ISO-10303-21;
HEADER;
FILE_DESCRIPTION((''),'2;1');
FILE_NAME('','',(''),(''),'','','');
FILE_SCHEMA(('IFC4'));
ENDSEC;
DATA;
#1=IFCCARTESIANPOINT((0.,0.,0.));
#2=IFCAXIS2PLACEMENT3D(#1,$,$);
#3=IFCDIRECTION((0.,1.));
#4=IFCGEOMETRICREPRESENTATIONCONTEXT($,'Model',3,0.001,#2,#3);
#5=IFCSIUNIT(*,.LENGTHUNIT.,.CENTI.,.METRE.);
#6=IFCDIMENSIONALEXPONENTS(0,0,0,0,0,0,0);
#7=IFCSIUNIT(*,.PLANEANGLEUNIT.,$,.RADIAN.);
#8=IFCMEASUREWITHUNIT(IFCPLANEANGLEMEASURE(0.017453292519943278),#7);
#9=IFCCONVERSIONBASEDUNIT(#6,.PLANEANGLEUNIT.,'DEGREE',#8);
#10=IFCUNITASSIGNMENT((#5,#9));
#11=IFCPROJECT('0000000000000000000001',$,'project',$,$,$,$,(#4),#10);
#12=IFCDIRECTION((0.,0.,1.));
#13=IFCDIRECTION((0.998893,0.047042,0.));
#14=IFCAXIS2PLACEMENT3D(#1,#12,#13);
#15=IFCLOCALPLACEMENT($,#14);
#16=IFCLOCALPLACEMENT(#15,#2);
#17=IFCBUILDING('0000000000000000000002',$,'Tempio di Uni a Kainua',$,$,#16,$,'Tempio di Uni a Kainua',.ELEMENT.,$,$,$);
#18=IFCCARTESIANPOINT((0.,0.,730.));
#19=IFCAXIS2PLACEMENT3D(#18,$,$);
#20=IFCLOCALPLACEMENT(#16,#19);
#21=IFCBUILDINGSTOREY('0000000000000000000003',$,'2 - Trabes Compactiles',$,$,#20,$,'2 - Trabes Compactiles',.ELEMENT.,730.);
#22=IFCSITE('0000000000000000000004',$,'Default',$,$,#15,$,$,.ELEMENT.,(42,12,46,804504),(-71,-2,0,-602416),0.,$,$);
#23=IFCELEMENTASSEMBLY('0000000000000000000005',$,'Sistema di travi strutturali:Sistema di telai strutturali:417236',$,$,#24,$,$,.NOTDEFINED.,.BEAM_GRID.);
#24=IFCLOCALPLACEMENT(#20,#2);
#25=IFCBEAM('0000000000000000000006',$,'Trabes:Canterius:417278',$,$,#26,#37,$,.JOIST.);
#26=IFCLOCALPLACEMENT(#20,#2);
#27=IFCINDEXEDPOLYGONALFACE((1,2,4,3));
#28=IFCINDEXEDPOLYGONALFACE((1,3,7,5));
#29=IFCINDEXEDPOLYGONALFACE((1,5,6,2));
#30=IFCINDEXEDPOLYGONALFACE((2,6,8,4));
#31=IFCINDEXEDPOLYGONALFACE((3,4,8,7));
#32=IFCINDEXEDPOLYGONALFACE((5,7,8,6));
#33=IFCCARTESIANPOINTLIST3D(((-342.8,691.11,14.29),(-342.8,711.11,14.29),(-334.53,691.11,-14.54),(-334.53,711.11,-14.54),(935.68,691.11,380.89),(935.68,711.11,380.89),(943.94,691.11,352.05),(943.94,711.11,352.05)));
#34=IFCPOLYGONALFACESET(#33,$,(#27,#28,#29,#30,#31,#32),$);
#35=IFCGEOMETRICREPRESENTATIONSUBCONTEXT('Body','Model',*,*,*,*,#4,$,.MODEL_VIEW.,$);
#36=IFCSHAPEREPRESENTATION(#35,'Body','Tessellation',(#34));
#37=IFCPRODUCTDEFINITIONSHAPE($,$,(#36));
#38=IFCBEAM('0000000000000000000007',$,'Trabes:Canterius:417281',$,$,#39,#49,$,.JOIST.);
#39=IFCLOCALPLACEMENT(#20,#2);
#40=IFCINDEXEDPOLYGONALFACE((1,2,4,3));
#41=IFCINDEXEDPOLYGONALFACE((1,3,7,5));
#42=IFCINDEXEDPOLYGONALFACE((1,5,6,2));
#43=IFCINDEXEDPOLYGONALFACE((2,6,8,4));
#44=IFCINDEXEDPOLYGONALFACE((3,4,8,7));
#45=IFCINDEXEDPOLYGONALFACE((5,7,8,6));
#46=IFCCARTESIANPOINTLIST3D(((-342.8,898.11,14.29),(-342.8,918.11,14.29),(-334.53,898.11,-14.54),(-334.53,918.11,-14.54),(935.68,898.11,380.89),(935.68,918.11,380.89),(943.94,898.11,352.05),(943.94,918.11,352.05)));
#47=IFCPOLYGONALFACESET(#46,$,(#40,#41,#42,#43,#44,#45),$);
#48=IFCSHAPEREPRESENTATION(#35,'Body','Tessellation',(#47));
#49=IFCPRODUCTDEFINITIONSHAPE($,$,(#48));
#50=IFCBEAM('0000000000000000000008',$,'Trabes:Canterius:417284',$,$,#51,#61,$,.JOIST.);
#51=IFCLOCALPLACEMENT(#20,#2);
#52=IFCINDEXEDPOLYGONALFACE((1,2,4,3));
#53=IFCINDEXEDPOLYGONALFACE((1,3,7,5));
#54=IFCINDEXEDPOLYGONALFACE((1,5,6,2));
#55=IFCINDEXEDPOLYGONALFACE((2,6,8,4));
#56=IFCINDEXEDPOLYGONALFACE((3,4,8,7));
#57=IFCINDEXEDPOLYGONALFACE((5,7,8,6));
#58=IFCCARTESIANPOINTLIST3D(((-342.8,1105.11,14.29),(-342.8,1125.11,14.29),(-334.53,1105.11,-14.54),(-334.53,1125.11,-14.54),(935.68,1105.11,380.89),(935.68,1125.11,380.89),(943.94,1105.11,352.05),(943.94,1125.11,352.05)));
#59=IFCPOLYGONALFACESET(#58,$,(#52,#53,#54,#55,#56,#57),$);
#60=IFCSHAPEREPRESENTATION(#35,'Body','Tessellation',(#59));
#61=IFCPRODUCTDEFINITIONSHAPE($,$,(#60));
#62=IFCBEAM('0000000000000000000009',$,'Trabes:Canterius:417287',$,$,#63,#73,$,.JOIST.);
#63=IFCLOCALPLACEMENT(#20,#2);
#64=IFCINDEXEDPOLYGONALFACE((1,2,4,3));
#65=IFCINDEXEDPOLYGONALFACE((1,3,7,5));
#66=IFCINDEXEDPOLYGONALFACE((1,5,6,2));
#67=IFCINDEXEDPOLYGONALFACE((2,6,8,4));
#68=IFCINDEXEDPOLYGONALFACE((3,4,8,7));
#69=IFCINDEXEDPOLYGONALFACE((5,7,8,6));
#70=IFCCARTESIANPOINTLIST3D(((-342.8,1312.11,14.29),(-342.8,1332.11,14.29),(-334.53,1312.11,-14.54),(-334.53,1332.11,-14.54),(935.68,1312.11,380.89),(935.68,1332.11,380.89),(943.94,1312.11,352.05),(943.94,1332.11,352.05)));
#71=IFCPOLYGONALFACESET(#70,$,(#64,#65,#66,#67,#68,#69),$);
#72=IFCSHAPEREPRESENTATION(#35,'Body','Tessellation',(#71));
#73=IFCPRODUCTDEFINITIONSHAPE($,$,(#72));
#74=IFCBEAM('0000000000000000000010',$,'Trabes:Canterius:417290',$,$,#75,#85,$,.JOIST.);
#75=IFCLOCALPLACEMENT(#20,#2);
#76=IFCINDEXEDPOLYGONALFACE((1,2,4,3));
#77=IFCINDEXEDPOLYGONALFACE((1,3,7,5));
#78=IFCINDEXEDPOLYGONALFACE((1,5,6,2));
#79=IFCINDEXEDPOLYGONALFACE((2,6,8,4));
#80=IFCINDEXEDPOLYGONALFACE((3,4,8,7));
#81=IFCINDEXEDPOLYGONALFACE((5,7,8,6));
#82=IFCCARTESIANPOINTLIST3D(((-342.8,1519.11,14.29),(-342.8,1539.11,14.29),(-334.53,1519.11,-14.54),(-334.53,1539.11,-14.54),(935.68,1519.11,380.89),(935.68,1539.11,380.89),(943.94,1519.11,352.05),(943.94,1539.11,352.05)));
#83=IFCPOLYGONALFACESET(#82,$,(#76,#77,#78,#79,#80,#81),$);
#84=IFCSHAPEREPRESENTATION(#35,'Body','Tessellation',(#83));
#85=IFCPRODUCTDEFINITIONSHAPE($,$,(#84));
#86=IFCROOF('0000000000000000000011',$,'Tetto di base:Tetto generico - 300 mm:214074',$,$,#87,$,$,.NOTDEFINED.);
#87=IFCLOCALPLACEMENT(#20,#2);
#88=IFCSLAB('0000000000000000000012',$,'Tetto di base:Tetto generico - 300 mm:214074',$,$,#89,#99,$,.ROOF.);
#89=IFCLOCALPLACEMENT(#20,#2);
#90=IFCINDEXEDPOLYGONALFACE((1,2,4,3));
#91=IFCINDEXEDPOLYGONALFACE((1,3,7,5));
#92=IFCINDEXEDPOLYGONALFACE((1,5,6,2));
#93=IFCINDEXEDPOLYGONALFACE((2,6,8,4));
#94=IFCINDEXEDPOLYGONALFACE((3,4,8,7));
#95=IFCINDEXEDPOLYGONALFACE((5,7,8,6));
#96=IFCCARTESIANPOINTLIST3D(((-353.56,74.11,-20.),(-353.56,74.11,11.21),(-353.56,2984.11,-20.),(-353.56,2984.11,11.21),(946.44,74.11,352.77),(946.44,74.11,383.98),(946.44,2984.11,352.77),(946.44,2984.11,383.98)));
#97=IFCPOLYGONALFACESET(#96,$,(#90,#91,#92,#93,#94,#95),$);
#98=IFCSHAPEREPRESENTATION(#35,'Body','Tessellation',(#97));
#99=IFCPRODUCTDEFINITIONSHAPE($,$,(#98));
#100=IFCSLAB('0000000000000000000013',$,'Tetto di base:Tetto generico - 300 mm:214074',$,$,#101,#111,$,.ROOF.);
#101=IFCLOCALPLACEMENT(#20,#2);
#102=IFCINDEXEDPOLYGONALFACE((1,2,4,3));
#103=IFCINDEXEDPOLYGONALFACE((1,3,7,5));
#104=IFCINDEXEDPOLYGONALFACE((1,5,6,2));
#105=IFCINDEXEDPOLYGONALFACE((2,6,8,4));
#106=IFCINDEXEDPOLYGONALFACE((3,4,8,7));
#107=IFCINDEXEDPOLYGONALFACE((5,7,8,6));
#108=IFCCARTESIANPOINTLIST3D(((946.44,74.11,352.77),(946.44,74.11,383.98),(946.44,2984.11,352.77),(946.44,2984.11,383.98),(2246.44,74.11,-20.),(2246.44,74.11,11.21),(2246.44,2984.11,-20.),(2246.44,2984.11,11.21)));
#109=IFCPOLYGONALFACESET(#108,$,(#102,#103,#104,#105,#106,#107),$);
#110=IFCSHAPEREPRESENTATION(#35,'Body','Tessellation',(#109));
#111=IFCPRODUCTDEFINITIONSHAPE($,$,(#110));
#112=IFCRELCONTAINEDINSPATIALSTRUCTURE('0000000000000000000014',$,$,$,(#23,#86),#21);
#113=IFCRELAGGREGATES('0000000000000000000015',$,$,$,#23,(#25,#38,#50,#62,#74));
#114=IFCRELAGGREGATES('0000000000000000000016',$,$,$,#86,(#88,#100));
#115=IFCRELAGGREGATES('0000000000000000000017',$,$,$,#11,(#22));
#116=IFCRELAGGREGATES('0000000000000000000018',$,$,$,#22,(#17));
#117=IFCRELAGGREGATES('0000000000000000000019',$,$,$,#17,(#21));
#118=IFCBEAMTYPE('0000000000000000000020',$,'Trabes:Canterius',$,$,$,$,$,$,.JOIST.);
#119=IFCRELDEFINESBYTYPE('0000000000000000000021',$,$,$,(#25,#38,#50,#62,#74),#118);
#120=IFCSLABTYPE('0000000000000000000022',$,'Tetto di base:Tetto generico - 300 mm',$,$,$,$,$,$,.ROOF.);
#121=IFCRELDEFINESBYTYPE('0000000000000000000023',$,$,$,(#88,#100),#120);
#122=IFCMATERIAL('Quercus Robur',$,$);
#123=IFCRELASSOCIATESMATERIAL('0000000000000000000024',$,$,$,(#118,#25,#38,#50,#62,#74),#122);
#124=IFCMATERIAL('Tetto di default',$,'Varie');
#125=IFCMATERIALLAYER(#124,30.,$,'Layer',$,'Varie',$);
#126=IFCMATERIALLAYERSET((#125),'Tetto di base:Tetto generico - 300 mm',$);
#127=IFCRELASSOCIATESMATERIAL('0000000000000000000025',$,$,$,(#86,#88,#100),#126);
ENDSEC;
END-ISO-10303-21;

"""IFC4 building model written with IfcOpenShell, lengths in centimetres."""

from ifc_helpers import new_model, entity, si_unit, converted_unit, direction, frame, frame_2d, origin, origin_2d_with_axis, place, context, subcontext, project, spatial, rectangle, extrude, source, transform, mapped, material, layer, layer_set, material_profile, profile_set, profile_usage, type_object, type_shapes, element, aggregate, save


model = new_model("IFC4")

# Units and contexts
model_context = context("Model", 3, precision=0.001, world=origin(), true_north=direction((0.0, 1.0)))
body_context = subcontext(model_context, "Body", "Model", "MODEL_VIEW")
ifc_project = project(units=[si_unit("LENGTHUNIT", "METRE", prefix="CENTI"), converted_unit("PLANEANGLEUNIT", "DEGREE", entity("IfcPlaneAngleMeasure", 0.017453292519943278), si_unit("PLANEANGLEUNIT", "RADIAN"), dimensions=[0, 0, 0, 0, 0, 0, 0])], contexts=[model_context])

# Site, building, storey
site_placement = place(None, frame((0.0, 0.0, 0.0), z_axis=(0.0, 0.0, 1.0), x_axis=(0.998893, 0.047042, 0.0)))
site = spatial("IfcSite", under=ifc_project, at=site_placement, Name="Default", CompositionType="ELEMENT", RefLatitude=(42, 12, 46, 804504), RefLongitude=(-71, -2, 0, -602416), RefElevation=0.0)
building_placement = place(site_placement, origin())
building = spatial("IfcBuilding", under=site, at=building_placement, Name="Tempio di Uni a Kainua", LongName="Tempio di Uni a Kainua", CompositionType="ELEMENT")
storey_placement = place(building_placement, frame((0.0, 0.0, 730.0)))
storey = spatial("IfcBuildingStorey", under=building, at=storey_placement, Name="2 - Trabes Compactiles", LongName="2 - Trabes Compactiles", CompositionType="ELEMENT", Elevation=730.0)

# Element assembly, beams
ifc_material_1 = material(Name="Quercus Robur")
assembly_1_placement = place(storey_placement, origin())
assembly_1 = element("IfcElementAssembly", 1, at=assembly_1_placement, inside=storey, Name="Sistema di travi strutturali:Sistema di telai strutturali:417236", AssemblyPlace="NOTDEFINED", PredefinedType="BEAM_GRID")
ifc_material_profile_1 = material_profile(ifc_material_1, rectangle(XDim=2590.0, YDim=20.0, at=origin_2d_with_axis()), Name="Canterius")
ifc_profile_set_1 = profile_set([ifc_material_profile_1], Name="Canterius")
ifc_profile_usage_1 = profile_usage(ifc_profile_set_1, cardinal=8)
beam_type_1 = type_object("IfcBeamType", Name="Trabes:Canterius", PredefinedType="JOIST", material=ifc_profile_set_1)
shared_shape_1 = source(origin(), body_context, "Body", "SweptSolid", [
    extrude(rectangle(XDim=1330.0, YDim=20.0, at=origin_2d_with_axis()), frame((0.0, 0.0, -15.0)), (0.0, 0.0, 1.0), 30.0),
])
type_shapes(beam_type_1, [shared_shape_1])
beam_1_placement = place(assembly_1_placement, frame((300.57, 701.11, 183.17), z_axis=(-0.275637, 0.0, 0.961262), x_axis=(0.961262, 0.0, 0.275637)))
beam_1 = element("IfcBeam", 2, at=beam_1_placement, type_object=beam_type_1, material=ifc_profile_usage_1, Name="Trabes:Canterius:417278", PredefinedType="JOIST", context=body_context, shape_type="MappedRepresentation", body=[
    mapped(shared_shape_1, transform((0.0, 0.0, 0.0), scale=1.0)),
])
beam_2_placement = place(assembly_1_placement, frame((300.57, 908.11, 183.17), z_axis=(-0.275637, 0.0, 0.961262), x_axis=(0.961262, 0.0, 0.275637)))
beam_2 = element("IfcBeam", 3, at=beam_2_placement, type_object=beam_type_1, material=ifc_profile_usage_1, Name="Trabes:Canterius:417281", PredefinedType="JOIST", context=body_context, shape_type="MappedRepresentation", body=[
    mapped(shared_shape_1, transform((0.0, 0.0, 0.0), scale=1.0)),
])
beam_3_placement = place(assembly_1_placement, frame((300.57, 1115.11, 183.17), z_axis=(-0.275637, 0.0, 0.961262), x_axis=(0.961262, 0.0, 0.275637)))
beam_3 = element("IfcBeam", 4, at=beam_3_placement, type_object=beam_type_1, material=ifc_profile_usage_1, Name="Trabes:Canterius:417284", PredefinedType="JOIST", context=body_context, shape_type="MappedRepresentation", body=[
    mapped(shared_shape_1, transform((0.0, 0.0, 0.0), scale=1.0)),
])
beam_4_placement = place(assembly_1_placement, frame((300.57, 1322.11, 183.17), z_axis=(-0.275637, 0.0, 0.961262), x_axis=(0.961262, 0.0, 0.275637)))
beam_4 = element("IfcBeam", 5, at=beam_4_placement, type_object=beam_type_1, material=ifc_profile_usage_1, Name="Trabes:Canterius:417287", PredefinedType="JOIST", context=body_context, shape_type="MappedRepresentation", body=[
    mapped(shared_shape_1, transform((0.0, 0.0, 0.0), scale=1.0)),
])
beam_5_placement = place(assembly_1_placement, frame((300.57, 1529.11, 183.17), z_axis=(-0.275637, 0.0, 0.961262), x_axis=(0.961262, 0.0, 0.275637)))
beam_5 = element("IfcBeam", 6, at=beam_5_placement, type_object=beam_type_1, material=ifc_profile_usage_1, Name="Trabes:Canterius:417290", PredefinedType="JOIST", context=body_context, shape_type="MappedRepresentation", body=[
    mapped(shared_shape_1, transform((0.0, 0.0, 0.0), scale=1.0)),
])
aggregate(assembly_1, [beam_1, beam_2, beam_3, beam_4, beam_5])

# Roof, slabs
ifc_material_2 = material(Name="Tetto di default", Category="Varie")
ifc_layer = layer(ifc_material_2, 30.0, Name="Layer", Category="Varie")
ifc_layer_set = layer_set([ifc_layer], Name="Tetto di base:Tetto generico - 300 mm")
roof_placement = place(storey_placement, frame((-353.56, 74.11, -20.0)))
roof = element("IfcRoof", 7, at=roof_placement, inside=storey, material=ifc_layer_set, Name="Tetto di base:Tetto generico - 300 mm:214074", PredefinedType="NOTDEFINED")
slab_type = type_object("IfcSlabType", Name="Tetto di base:Tetto generico - 300 mm", PredefinedType="ROOF")
slab_1_placement = place(roof_placement, origin())
slab_1 = element("IfcSlab", 8, at=slab_1_placement, type_object=slab_type, material=ifc_layer_set, Name="Tetto di base:Tetto generico - 300 mm:214074", PredefinedType="ROOF", context=body_context, shape_type="SweptSolid", body=[
    extrude(rectangle(XDim=2910.0, YDim=1352.39, at=frame_2d((0.0, 0.0), x_axis=(0.0, 1.0))), frame((650.0, 1455.0, 186.38), z_axis=(-0.275637, 0.0, 0.961262), x_axis=(0.961262, 0.0, 0.275637)), (0.275637, 0.0, 0.961262), 31.21),
])
slab_2_placement = place(roof_placement, origin())
slab_2 = element("IfcSlab", 9, at=slab_2_placement, type_object=slab_type, material=ifc_layer_set, Name="Tetto di base:Tetto generico - 300 mm:214074", PredefinedType="ROOF", context=body_context, shape_type="SweptSolid", body=[
    extrude(rectangle(XDim=1352.39, YDim=2910.0, at=frame_2d((0.0, 0.0), x_axis=(1.0, 0.0))), frame((1950.0, 1455.0, 186.38), z_axis=(0.275637, 0.0, 0.961262), x_axis=(0.961262, 0.0, -0.275637)), (-0.275637, 0.0, 0.961262), 31.21),
])
aggregate(roof, [slab_1, slab_2])

save(model, "model.ifc")
